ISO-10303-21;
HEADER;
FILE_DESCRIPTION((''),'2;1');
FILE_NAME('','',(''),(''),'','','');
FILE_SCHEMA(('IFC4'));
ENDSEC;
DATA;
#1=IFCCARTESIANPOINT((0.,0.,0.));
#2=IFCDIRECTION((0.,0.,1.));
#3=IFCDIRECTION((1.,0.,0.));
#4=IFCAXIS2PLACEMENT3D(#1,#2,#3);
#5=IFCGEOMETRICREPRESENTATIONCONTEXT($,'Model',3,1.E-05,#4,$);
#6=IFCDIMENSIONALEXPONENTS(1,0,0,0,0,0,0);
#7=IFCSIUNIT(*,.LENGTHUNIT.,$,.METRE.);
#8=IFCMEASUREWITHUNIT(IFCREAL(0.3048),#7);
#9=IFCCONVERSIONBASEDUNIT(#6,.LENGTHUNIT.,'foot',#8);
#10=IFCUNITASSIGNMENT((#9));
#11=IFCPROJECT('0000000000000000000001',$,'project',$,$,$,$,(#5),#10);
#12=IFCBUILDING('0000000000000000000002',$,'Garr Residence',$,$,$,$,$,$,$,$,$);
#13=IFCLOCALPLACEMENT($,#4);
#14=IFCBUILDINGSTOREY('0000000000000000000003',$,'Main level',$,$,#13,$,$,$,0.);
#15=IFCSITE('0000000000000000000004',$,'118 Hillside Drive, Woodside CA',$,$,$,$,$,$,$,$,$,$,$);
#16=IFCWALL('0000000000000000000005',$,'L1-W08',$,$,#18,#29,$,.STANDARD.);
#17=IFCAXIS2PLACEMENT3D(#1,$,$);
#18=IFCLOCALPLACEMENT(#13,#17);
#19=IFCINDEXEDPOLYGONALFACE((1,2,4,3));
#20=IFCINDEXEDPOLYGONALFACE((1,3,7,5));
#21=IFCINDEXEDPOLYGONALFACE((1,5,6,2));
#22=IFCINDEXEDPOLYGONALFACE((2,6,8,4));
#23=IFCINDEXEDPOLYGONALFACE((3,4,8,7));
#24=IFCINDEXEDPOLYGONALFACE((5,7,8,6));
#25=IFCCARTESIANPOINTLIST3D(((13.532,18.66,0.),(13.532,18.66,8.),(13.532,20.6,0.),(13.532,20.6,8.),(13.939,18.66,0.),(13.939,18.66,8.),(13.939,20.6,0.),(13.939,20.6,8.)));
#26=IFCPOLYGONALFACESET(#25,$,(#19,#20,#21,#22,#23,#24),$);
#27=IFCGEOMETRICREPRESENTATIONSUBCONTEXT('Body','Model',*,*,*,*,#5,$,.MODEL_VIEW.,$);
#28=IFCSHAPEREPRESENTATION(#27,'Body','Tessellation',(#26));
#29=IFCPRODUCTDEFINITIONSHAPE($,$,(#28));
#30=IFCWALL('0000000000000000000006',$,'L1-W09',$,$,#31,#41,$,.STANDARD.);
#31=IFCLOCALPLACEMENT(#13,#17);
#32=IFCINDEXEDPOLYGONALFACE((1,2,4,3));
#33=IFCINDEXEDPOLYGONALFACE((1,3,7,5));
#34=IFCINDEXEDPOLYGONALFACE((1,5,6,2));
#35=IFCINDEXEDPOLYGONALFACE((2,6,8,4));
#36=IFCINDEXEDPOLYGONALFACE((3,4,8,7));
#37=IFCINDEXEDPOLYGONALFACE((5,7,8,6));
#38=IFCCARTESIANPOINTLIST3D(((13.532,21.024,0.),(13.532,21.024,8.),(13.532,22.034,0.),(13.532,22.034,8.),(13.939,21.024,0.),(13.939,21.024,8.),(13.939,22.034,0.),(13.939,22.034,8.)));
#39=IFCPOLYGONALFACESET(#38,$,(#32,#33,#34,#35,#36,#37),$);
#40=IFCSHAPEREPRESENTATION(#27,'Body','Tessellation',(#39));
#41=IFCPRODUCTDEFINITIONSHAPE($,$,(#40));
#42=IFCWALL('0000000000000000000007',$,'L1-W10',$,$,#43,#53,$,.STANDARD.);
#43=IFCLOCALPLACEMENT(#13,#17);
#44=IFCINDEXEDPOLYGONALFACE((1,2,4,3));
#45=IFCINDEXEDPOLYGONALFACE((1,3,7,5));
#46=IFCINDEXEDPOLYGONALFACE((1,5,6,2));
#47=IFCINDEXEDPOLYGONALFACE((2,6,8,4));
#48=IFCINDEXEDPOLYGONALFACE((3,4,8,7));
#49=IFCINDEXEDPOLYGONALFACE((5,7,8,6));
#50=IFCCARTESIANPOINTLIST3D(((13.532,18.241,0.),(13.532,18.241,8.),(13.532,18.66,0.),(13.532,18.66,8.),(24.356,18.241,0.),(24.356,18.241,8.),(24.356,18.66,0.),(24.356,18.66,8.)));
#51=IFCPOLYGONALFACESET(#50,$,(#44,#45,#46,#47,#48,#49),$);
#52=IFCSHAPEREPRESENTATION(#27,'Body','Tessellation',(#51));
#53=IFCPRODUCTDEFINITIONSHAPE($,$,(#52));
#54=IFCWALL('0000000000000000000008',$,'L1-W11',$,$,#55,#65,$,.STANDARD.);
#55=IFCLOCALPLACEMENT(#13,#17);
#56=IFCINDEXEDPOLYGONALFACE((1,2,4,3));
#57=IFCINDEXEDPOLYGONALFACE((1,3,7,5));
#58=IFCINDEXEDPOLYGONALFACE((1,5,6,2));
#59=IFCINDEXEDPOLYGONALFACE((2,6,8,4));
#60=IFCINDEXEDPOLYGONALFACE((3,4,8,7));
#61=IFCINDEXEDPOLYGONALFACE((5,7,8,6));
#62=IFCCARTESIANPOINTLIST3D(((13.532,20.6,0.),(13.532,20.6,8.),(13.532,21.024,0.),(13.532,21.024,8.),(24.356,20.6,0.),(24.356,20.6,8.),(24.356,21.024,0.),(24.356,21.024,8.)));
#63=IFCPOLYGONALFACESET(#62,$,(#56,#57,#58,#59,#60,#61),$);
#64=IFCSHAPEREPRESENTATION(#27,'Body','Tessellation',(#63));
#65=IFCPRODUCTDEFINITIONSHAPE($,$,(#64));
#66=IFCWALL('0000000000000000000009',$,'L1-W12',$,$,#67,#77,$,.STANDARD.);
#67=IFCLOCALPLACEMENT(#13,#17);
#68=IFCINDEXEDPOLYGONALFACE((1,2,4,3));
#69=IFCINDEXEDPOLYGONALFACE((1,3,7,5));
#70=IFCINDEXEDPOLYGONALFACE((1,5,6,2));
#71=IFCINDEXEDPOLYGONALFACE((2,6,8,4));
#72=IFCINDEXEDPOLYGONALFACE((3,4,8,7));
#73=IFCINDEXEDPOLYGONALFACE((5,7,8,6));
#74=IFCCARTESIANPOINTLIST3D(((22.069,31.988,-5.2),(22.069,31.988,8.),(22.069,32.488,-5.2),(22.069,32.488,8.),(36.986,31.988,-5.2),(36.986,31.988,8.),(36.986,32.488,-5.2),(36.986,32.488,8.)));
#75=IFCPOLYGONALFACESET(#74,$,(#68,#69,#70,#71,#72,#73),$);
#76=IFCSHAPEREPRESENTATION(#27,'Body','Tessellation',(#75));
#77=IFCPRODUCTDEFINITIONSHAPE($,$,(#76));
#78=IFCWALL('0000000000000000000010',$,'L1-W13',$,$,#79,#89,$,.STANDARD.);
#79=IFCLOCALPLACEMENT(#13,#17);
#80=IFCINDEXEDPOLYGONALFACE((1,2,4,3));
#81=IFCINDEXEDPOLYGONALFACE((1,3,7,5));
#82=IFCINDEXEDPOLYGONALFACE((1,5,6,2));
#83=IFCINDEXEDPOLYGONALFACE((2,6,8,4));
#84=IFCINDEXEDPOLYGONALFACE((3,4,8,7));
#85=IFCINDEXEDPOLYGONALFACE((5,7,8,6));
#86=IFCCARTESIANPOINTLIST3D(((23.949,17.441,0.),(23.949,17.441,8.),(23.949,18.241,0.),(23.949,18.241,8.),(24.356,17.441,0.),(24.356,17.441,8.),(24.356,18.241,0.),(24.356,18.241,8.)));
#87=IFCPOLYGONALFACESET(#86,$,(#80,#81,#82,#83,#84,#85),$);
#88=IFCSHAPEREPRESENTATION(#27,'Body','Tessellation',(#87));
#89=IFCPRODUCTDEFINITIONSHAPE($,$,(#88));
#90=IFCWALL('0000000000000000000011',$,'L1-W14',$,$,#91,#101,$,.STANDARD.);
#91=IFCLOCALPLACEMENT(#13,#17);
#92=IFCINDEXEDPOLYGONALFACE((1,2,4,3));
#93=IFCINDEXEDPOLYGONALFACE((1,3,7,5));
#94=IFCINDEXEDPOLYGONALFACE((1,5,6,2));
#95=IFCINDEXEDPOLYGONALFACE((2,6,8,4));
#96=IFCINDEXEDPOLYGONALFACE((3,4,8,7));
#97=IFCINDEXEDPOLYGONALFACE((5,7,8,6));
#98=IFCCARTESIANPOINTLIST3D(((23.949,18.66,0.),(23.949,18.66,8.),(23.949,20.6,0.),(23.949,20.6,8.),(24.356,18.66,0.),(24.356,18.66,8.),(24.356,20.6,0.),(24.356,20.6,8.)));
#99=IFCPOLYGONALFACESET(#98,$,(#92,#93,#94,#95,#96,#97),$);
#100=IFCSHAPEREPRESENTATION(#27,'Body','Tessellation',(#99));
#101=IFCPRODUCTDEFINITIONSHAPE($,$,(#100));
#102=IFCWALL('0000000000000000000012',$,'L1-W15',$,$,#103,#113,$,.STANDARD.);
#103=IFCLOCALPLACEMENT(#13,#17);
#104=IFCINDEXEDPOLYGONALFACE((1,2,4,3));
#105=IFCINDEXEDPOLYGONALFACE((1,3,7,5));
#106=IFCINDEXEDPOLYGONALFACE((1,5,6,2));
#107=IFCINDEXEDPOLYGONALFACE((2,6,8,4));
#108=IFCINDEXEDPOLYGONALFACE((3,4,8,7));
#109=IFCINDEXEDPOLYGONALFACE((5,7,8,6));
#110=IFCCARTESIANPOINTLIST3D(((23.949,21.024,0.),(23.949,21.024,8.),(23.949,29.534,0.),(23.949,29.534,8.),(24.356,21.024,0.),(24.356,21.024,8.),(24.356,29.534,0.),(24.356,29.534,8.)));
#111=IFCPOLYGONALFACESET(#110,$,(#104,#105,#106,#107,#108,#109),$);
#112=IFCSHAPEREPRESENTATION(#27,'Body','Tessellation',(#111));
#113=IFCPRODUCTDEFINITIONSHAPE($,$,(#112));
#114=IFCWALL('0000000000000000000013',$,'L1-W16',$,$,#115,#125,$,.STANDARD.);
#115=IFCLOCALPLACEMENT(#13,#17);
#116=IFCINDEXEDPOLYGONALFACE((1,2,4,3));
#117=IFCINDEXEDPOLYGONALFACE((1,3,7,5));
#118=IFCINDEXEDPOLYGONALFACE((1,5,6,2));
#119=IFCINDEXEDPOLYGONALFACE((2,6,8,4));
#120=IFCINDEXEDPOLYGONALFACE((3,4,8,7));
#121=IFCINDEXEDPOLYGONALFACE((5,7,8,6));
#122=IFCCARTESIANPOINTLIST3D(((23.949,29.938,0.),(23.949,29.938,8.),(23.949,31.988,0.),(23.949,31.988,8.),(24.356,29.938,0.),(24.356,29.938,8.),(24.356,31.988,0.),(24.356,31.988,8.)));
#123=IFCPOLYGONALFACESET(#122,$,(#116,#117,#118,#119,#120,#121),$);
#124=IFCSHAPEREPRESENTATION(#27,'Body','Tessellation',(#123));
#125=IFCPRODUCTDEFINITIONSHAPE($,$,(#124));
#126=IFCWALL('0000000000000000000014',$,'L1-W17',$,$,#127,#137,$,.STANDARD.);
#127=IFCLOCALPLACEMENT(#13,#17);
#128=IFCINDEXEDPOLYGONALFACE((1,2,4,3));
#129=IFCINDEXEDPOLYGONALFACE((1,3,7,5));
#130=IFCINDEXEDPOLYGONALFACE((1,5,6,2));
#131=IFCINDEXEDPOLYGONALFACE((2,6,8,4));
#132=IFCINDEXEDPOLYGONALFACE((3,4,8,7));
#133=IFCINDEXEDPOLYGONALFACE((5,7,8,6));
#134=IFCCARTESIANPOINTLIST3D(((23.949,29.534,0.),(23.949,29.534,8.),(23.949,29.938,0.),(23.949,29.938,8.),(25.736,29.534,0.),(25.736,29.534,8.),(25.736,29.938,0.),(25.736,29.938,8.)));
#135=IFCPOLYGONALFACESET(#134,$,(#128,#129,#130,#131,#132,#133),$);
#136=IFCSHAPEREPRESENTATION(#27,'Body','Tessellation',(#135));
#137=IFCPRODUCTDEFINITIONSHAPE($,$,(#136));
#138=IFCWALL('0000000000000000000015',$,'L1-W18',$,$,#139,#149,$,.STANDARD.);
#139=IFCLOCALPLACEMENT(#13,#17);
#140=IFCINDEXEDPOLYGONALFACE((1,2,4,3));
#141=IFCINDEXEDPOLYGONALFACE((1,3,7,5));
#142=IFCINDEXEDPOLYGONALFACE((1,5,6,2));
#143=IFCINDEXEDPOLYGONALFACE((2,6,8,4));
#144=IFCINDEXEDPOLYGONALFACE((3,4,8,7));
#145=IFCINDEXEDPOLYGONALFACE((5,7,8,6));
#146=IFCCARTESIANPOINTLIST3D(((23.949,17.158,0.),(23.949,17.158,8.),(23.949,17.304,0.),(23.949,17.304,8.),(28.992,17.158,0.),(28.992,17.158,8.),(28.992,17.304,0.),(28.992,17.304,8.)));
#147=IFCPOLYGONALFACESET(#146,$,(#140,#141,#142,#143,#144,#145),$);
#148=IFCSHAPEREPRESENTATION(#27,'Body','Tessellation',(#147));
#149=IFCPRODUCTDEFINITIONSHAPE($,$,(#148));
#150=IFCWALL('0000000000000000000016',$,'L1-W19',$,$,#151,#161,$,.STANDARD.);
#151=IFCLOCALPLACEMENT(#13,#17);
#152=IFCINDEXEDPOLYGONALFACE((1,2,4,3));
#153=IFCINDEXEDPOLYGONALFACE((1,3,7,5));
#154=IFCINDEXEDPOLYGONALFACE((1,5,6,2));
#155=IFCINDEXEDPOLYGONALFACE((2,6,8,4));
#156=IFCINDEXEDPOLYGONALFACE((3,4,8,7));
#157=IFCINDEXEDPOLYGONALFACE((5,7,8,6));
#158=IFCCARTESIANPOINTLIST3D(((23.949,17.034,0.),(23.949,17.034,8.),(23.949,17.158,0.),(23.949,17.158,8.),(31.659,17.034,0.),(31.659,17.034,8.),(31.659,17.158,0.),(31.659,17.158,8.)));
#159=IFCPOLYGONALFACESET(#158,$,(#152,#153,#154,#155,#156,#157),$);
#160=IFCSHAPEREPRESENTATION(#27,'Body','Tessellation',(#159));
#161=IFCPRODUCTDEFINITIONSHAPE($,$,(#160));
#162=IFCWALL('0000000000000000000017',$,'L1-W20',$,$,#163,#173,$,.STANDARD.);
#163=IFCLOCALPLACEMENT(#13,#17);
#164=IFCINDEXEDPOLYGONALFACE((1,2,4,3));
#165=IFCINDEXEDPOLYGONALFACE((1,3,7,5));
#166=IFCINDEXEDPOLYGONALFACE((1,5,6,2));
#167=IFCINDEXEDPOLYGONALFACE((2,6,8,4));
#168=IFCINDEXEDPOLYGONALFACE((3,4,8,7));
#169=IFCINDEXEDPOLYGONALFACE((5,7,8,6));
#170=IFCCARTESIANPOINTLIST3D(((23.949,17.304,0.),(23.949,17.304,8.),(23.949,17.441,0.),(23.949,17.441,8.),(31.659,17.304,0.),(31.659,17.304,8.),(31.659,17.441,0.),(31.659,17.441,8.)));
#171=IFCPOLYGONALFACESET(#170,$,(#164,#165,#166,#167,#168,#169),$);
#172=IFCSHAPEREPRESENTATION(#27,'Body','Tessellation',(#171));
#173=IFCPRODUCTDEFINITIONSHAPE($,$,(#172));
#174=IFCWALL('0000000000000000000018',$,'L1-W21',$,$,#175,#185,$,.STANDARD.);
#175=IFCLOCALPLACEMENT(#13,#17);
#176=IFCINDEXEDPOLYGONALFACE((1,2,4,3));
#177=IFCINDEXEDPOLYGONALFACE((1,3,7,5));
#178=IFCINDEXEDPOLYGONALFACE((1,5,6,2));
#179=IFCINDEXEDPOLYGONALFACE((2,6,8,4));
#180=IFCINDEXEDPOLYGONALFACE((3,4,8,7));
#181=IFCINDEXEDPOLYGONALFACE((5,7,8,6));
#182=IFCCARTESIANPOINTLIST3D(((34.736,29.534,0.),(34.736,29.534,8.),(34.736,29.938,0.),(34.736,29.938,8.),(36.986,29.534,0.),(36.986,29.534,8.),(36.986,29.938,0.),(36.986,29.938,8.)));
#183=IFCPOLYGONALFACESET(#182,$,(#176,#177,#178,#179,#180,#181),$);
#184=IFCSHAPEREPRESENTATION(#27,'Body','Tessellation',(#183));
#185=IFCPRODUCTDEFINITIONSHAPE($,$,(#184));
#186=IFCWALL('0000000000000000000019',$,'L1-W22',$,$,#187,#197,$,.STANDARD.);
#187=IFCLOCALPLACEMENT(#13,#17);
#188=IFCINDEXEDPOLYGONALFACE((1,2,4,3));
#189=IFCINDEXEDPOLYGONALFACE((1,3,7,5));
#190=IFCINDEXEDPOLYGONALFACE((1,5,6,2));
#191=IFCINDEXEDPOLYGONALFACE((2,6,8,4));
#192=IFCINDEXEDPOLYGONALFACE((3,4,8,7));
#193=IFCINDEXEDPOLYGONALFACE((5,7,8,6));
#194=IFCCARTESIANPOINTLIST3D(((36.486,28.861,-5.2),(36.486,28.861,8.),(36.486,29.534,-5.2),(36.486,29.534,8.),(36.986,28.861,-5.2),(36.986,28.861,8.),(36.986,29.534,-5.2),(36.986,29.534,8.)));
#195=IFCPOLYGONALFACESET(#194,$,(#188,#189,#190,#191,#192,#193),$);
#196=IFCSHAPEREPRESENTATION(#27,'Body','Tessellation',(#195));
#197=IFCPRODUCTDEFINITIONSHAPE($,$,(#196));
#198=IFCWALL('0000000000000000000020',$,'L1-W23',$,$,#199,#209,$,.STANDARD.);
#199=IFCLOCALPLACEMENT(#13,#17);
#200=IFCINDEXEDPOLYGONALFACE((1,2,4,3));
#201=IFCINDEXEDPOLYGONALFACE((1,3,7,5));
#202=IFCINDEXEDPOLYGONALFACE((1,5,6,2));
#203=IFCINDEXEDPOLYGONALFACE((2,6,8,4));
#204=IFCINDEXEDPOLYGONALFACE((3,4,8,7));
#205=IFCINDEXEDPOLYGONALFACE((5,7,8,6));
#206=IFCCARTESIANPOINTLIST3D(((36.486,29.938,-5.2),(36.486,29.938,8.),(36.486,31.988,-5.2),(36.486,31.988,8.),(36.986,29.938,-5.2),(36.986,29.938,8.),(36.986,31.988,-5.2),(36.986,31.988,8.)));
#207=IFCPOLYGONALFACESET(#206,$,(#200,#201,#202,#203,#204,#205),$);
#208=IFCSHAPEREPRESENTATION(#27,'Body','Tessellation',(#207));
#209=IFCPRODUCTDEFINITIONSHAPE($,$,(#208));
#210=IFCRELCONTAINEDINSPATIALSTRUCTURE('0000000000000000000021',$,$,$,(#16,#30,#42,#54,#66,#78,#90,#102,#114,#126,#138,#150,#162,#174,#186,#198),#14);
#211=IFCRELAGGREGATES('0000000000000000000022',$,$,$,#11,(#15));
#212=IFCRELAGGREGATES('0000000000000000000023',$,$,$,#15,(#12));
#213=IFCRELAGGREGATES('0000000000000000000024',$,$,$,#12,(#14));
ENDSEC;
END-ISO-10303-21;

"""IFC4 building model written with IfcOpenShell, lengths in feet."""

from ifc_helpers import new_model, entity, si_unit, converted_unit, frame, origin, origin_with_axes, place, context, subcontext, project, spatial, polyline, outline, extrude, element, save


model = new_model("IFC4")

# Units and contexts
model_context = context("Model", 3, precision=1e-05, world=origin_with_axes())
body_context = subcontext(model_context, "Body", "Model", "MODEL_VIEW")
ifc_project = project(units=[converted_unit("LENGTHUNIT", "foot", entity("IfcReal", 0.3048), si_unit("LENGTHUNIT", "METRE"), dimensions=[1, 0, 0, 0, 0, 0, 0])], contexts=[model_context])

# Site, building, storey
site = spatial("IfcSite", under=ifc_project, Name="118 Hillside Drive, Woodside CA")
building = spatial("IfcBuilding", under=site, Name="Garr Residence")
storey_placement = place(None, origin_with_axes())
storey = spatial("IfcBuildingStorey", under=building, at=storey_placement, Name="Main level", Elevation=0.0)

# Walls
wall_1_placement = place(storey_placement, origin_with_axes())
element("IfcWall", 1, at=wall_1_placement, inside=storey, Name="L1-W08", PredefinedType="STANDARD", context=body_context, shape_type="SweptSolid", body=[
    extrude(outline(polyline([(13.939, 18.66), (13.939, 20.6), (13.532, 20.6), (13.532, 18.66), (13.939, 18.66)])), origin(), (0.0, 0.0, 1.0), 8.0),
])
wall_2_placement = place(storey_placement, origin_with_axes())
element("IfcWall", 2, at=wall_2_placement, inside=storey, Name="L1-W09", PredefinedType="STANDARD", context=body_context, shape_type="SweptSolid", body=[
    extrude(outline(polyline([(13.939, 21.024), (13.939, 22.034), (13.532, 22.034), (13.532, 21.024), (13.939, 21.024)])), origin(), (0.0, 0.0, 1.0), 8.0),
])
wall_3_placement = place(storey_placement, origin_with_axes())
element("IfcWall", 3, at=wall_3_placement, inside=storey, Name="L1-W10", PredefinedType="STANDARD", context=body_context, shape_type="SweptSolid", body=[
    extrude(outline(polyline([(24.356, 18.241), (24.356, 18.66), (13.532, 18.66), (13.532, 18.241), (24.356, 18.241)])), origin(), (0.0, 0.0, 1.0), 8.0),
])
wall_4_placement = place(storey_placement, origin_with_axes())
element("IfcWall", 4, at=wall_4_placement, inside=storey, Name="L1-W11", PredefinedType="STANDARD", context=body_context, shape_type="SweptSolid", body=[
    extrude(outline(polyline([(24.356, 20.6), (24.356, 21.024), (13.532, 21.024), (13.532, 20.6), (24.356, 20.6)])), origin(), (0.0, 0.0, 1.0), 8.0),
])
wall_5_placement = place(storey_placement, frame((0.0, 0.0, -5.2), z_axis=(0.0, 0.0, 1.0), x_axis=(1.0, 0.0, 0.0)))
element("IfcWall", 5, at=wall_5_placement, inside=storey, Name="L1-W12", PredefinedType="STANDARD", context=body_context, shape_type="SweptSolid", body=[
    extrude(outline(polyline([(36.986, 31.988), (36.986, 32.488), (22.069, 32.488), (22.069, 31.988), (36.986, 31.988)])), origin(), (0.0, 0.0, 1.0), 13.2),
])
wall_6_placement = place(storey_placement, origin_with_axes())
element("IfcWall", 6, at=wall_6_placement, inside=storey, Name="L1-W13", PredefinedType="STANDARD", context=body_context, shape_type="SweptSolid", body=[
    extrude(outline(polyline([(24.356, 17.441), (24.356, 18.241), (23.949, 18.241), (23.949, 17.441), (24.356, 17.441)])), origin(), (0.0, 0.0, 1.0), 8.0),
])
wall_7_placement = place(storey_placement, origin_with_axes())
element("IfcWall", 7, at=wall_7_placement, inside=storey, Name="L1-W14", PredefinedType="STANDARD", context=body_context, shape_type="SweptSolid", body=[
    extrude(outline(polyline([(24.356, 18.66), (24.356, 20.6), (23.949, 20.6), (23.949, 18.66), (24.356, 18.66)])), origin(), (0.0, 0.0, 1.0), 8.0),
])
wall_8_placement = place(storey_placement, origin_with_axes())
element("IfcWall", 8, at=wall_8_placement, inside=storey, Name="L1-W15", PredefinedType="STANDARD", context=body_context, shape_type="SweptSolid", body=[
    extrude(outline(polyline([(24.356, 21.024), (24.356, 29.534), (23.949, 29.534), (23.949, 21.024), (24.356, 21.024)])), origin(), (0.0, 0.0, 1.0), 8.0),
])
wall_9_placement = place(storey_placement, origin_with_axes())
element("IfcWall", 9, at=wall_9_placement, inside=storey, Name="L1-W16", PredefinedType="STANDARD", context=body_context, shape_type="SweptSolid", body=[
    extrude(outline(polyline([(24.356, 29.938), (24.356, 31.988), (23.949, 31.988), (23.949, 29.938), (24.356, 29.938)])), origin(), (0.0, 0.0, 1.0), 8.0),
])
wall_10_placement = place(storey_placement, origin_with_axes())
element("IfcWall", 10, at=wall_10_placement, inside=storey, Name="L1-W17", PredefinedType="STANDARD", context=body_context, shape_type="SweptSolid", body=[
    extrude(outline(polyline([(25.736, 29.534), (25.736, 29.938), (23.949, 29.938), (23.949, 29.534), (25.736, 29.534)])), origin(), (0.0, 0.0, 1.0), 8.0),
])
wall_11_placement = place(storey_placement, origin_with_axes())
element("IfcWall", 11, at=wall_11_placement, inside=storey, Name="L1-W18", PredefinedType="STANDARD", context=body_context, shape_type="SweptSolid", body=[
    extrude(outline(polyline([(28.992, 17.158), (28.992, 17.304), (23.949, 17.304), (23.949, 17.158), (28.992, 17.158)])), origin(), (0.0, 0.0, 1.0), 8.0),
])
wall_12_placement = place(storey_placement, origin_with_axes())
element("IfcWall", 12, at=wall_12_placement, inside=storey, Name="L1-W19", PredefinedType="STANDARD", context=body_context, shape_type="SweptSolid", body=[
    extrude(outline(polyline([(31.659, 17.034), (31.659, 17.158), (23.949, 17.158), (23.949, 17.034), (31.659, 17.034)])), origin(), (0.0, 0.0, 1.0), 8.0),
])
wall_13_placement = place(storey_placement, origin_with_axes())
element("IfcWall", 13, at=wall_13_placement, inside=storey, Name="L1-W20", PredefinedType="STANDARD", context=body_context, shape_type="SweptSolid", body=[
    extrude(outline(polyline([(31.659, 17.304), (31.659, 17.441), (23.949, 17.441), (23.949, 17.304), (31.659, 17.304)])), origin(), (0.0, 0.0, 1.0), 8.0),
])
wall_14_placement = place(storey_placement, origin_with_axes())
element("IfcWall", 14, at=wall_14_placement, inside=storey, Name="L1-W21", PredefinedType="STANDARD", context=body_context, shape_type="SweptSolid", body=[
    extrude(outline(polyline([(36.986, 29.534), (36.986, 29.938), (34.736, 29.938), (34.736, 29.534), (36.986, 29.534)])), origin(), (0.0, 0.0, 1.0), 8.0),
])
wall_15_placement = place(storey_placement, frame((0.0, 0.0, -5.2), z_axis=(0.0, 0.0, 1.0), x_axis=(1.0, 0.0, 0.0)))
element("IfcWall", 15, at=wall_15_placement, inside=storey, Name="L1-W22", PredefinedType="STANDARD", context=body_context, shape_type="SweptSolid", body=[
    extrude(outline(polyline([(36.986, 28.861), (36.986, 29.534), (36.486, 29.534), (36.486, 28.861), (36.986, 28.861)])), origin(), (0.0, 0.0, 1.0), 13.2),
])
wall_16_placement = place(storey_placement, frame((0.0, 0.0, -5.2), z_axis=(0.0, 0.0, 1.0), x_axis=(1.0, 0.0, 0.0)))
element("IfcWall", 16, at=wall_16_placement, inside=storey, Name="L1-W23", PredefinedType="STANDARD", context=body_context, shape_type="SweptSolid", body=[
    extrude(outline(polyline([(36.986, 29.938), (36.986, 31.988), (36.486, 31.988), (36.486, 29.938), (36.986, 29.938)])), origin(), (0.0, 0.0, 1.0), 13.2),
])

save(model, "model.ifc")
